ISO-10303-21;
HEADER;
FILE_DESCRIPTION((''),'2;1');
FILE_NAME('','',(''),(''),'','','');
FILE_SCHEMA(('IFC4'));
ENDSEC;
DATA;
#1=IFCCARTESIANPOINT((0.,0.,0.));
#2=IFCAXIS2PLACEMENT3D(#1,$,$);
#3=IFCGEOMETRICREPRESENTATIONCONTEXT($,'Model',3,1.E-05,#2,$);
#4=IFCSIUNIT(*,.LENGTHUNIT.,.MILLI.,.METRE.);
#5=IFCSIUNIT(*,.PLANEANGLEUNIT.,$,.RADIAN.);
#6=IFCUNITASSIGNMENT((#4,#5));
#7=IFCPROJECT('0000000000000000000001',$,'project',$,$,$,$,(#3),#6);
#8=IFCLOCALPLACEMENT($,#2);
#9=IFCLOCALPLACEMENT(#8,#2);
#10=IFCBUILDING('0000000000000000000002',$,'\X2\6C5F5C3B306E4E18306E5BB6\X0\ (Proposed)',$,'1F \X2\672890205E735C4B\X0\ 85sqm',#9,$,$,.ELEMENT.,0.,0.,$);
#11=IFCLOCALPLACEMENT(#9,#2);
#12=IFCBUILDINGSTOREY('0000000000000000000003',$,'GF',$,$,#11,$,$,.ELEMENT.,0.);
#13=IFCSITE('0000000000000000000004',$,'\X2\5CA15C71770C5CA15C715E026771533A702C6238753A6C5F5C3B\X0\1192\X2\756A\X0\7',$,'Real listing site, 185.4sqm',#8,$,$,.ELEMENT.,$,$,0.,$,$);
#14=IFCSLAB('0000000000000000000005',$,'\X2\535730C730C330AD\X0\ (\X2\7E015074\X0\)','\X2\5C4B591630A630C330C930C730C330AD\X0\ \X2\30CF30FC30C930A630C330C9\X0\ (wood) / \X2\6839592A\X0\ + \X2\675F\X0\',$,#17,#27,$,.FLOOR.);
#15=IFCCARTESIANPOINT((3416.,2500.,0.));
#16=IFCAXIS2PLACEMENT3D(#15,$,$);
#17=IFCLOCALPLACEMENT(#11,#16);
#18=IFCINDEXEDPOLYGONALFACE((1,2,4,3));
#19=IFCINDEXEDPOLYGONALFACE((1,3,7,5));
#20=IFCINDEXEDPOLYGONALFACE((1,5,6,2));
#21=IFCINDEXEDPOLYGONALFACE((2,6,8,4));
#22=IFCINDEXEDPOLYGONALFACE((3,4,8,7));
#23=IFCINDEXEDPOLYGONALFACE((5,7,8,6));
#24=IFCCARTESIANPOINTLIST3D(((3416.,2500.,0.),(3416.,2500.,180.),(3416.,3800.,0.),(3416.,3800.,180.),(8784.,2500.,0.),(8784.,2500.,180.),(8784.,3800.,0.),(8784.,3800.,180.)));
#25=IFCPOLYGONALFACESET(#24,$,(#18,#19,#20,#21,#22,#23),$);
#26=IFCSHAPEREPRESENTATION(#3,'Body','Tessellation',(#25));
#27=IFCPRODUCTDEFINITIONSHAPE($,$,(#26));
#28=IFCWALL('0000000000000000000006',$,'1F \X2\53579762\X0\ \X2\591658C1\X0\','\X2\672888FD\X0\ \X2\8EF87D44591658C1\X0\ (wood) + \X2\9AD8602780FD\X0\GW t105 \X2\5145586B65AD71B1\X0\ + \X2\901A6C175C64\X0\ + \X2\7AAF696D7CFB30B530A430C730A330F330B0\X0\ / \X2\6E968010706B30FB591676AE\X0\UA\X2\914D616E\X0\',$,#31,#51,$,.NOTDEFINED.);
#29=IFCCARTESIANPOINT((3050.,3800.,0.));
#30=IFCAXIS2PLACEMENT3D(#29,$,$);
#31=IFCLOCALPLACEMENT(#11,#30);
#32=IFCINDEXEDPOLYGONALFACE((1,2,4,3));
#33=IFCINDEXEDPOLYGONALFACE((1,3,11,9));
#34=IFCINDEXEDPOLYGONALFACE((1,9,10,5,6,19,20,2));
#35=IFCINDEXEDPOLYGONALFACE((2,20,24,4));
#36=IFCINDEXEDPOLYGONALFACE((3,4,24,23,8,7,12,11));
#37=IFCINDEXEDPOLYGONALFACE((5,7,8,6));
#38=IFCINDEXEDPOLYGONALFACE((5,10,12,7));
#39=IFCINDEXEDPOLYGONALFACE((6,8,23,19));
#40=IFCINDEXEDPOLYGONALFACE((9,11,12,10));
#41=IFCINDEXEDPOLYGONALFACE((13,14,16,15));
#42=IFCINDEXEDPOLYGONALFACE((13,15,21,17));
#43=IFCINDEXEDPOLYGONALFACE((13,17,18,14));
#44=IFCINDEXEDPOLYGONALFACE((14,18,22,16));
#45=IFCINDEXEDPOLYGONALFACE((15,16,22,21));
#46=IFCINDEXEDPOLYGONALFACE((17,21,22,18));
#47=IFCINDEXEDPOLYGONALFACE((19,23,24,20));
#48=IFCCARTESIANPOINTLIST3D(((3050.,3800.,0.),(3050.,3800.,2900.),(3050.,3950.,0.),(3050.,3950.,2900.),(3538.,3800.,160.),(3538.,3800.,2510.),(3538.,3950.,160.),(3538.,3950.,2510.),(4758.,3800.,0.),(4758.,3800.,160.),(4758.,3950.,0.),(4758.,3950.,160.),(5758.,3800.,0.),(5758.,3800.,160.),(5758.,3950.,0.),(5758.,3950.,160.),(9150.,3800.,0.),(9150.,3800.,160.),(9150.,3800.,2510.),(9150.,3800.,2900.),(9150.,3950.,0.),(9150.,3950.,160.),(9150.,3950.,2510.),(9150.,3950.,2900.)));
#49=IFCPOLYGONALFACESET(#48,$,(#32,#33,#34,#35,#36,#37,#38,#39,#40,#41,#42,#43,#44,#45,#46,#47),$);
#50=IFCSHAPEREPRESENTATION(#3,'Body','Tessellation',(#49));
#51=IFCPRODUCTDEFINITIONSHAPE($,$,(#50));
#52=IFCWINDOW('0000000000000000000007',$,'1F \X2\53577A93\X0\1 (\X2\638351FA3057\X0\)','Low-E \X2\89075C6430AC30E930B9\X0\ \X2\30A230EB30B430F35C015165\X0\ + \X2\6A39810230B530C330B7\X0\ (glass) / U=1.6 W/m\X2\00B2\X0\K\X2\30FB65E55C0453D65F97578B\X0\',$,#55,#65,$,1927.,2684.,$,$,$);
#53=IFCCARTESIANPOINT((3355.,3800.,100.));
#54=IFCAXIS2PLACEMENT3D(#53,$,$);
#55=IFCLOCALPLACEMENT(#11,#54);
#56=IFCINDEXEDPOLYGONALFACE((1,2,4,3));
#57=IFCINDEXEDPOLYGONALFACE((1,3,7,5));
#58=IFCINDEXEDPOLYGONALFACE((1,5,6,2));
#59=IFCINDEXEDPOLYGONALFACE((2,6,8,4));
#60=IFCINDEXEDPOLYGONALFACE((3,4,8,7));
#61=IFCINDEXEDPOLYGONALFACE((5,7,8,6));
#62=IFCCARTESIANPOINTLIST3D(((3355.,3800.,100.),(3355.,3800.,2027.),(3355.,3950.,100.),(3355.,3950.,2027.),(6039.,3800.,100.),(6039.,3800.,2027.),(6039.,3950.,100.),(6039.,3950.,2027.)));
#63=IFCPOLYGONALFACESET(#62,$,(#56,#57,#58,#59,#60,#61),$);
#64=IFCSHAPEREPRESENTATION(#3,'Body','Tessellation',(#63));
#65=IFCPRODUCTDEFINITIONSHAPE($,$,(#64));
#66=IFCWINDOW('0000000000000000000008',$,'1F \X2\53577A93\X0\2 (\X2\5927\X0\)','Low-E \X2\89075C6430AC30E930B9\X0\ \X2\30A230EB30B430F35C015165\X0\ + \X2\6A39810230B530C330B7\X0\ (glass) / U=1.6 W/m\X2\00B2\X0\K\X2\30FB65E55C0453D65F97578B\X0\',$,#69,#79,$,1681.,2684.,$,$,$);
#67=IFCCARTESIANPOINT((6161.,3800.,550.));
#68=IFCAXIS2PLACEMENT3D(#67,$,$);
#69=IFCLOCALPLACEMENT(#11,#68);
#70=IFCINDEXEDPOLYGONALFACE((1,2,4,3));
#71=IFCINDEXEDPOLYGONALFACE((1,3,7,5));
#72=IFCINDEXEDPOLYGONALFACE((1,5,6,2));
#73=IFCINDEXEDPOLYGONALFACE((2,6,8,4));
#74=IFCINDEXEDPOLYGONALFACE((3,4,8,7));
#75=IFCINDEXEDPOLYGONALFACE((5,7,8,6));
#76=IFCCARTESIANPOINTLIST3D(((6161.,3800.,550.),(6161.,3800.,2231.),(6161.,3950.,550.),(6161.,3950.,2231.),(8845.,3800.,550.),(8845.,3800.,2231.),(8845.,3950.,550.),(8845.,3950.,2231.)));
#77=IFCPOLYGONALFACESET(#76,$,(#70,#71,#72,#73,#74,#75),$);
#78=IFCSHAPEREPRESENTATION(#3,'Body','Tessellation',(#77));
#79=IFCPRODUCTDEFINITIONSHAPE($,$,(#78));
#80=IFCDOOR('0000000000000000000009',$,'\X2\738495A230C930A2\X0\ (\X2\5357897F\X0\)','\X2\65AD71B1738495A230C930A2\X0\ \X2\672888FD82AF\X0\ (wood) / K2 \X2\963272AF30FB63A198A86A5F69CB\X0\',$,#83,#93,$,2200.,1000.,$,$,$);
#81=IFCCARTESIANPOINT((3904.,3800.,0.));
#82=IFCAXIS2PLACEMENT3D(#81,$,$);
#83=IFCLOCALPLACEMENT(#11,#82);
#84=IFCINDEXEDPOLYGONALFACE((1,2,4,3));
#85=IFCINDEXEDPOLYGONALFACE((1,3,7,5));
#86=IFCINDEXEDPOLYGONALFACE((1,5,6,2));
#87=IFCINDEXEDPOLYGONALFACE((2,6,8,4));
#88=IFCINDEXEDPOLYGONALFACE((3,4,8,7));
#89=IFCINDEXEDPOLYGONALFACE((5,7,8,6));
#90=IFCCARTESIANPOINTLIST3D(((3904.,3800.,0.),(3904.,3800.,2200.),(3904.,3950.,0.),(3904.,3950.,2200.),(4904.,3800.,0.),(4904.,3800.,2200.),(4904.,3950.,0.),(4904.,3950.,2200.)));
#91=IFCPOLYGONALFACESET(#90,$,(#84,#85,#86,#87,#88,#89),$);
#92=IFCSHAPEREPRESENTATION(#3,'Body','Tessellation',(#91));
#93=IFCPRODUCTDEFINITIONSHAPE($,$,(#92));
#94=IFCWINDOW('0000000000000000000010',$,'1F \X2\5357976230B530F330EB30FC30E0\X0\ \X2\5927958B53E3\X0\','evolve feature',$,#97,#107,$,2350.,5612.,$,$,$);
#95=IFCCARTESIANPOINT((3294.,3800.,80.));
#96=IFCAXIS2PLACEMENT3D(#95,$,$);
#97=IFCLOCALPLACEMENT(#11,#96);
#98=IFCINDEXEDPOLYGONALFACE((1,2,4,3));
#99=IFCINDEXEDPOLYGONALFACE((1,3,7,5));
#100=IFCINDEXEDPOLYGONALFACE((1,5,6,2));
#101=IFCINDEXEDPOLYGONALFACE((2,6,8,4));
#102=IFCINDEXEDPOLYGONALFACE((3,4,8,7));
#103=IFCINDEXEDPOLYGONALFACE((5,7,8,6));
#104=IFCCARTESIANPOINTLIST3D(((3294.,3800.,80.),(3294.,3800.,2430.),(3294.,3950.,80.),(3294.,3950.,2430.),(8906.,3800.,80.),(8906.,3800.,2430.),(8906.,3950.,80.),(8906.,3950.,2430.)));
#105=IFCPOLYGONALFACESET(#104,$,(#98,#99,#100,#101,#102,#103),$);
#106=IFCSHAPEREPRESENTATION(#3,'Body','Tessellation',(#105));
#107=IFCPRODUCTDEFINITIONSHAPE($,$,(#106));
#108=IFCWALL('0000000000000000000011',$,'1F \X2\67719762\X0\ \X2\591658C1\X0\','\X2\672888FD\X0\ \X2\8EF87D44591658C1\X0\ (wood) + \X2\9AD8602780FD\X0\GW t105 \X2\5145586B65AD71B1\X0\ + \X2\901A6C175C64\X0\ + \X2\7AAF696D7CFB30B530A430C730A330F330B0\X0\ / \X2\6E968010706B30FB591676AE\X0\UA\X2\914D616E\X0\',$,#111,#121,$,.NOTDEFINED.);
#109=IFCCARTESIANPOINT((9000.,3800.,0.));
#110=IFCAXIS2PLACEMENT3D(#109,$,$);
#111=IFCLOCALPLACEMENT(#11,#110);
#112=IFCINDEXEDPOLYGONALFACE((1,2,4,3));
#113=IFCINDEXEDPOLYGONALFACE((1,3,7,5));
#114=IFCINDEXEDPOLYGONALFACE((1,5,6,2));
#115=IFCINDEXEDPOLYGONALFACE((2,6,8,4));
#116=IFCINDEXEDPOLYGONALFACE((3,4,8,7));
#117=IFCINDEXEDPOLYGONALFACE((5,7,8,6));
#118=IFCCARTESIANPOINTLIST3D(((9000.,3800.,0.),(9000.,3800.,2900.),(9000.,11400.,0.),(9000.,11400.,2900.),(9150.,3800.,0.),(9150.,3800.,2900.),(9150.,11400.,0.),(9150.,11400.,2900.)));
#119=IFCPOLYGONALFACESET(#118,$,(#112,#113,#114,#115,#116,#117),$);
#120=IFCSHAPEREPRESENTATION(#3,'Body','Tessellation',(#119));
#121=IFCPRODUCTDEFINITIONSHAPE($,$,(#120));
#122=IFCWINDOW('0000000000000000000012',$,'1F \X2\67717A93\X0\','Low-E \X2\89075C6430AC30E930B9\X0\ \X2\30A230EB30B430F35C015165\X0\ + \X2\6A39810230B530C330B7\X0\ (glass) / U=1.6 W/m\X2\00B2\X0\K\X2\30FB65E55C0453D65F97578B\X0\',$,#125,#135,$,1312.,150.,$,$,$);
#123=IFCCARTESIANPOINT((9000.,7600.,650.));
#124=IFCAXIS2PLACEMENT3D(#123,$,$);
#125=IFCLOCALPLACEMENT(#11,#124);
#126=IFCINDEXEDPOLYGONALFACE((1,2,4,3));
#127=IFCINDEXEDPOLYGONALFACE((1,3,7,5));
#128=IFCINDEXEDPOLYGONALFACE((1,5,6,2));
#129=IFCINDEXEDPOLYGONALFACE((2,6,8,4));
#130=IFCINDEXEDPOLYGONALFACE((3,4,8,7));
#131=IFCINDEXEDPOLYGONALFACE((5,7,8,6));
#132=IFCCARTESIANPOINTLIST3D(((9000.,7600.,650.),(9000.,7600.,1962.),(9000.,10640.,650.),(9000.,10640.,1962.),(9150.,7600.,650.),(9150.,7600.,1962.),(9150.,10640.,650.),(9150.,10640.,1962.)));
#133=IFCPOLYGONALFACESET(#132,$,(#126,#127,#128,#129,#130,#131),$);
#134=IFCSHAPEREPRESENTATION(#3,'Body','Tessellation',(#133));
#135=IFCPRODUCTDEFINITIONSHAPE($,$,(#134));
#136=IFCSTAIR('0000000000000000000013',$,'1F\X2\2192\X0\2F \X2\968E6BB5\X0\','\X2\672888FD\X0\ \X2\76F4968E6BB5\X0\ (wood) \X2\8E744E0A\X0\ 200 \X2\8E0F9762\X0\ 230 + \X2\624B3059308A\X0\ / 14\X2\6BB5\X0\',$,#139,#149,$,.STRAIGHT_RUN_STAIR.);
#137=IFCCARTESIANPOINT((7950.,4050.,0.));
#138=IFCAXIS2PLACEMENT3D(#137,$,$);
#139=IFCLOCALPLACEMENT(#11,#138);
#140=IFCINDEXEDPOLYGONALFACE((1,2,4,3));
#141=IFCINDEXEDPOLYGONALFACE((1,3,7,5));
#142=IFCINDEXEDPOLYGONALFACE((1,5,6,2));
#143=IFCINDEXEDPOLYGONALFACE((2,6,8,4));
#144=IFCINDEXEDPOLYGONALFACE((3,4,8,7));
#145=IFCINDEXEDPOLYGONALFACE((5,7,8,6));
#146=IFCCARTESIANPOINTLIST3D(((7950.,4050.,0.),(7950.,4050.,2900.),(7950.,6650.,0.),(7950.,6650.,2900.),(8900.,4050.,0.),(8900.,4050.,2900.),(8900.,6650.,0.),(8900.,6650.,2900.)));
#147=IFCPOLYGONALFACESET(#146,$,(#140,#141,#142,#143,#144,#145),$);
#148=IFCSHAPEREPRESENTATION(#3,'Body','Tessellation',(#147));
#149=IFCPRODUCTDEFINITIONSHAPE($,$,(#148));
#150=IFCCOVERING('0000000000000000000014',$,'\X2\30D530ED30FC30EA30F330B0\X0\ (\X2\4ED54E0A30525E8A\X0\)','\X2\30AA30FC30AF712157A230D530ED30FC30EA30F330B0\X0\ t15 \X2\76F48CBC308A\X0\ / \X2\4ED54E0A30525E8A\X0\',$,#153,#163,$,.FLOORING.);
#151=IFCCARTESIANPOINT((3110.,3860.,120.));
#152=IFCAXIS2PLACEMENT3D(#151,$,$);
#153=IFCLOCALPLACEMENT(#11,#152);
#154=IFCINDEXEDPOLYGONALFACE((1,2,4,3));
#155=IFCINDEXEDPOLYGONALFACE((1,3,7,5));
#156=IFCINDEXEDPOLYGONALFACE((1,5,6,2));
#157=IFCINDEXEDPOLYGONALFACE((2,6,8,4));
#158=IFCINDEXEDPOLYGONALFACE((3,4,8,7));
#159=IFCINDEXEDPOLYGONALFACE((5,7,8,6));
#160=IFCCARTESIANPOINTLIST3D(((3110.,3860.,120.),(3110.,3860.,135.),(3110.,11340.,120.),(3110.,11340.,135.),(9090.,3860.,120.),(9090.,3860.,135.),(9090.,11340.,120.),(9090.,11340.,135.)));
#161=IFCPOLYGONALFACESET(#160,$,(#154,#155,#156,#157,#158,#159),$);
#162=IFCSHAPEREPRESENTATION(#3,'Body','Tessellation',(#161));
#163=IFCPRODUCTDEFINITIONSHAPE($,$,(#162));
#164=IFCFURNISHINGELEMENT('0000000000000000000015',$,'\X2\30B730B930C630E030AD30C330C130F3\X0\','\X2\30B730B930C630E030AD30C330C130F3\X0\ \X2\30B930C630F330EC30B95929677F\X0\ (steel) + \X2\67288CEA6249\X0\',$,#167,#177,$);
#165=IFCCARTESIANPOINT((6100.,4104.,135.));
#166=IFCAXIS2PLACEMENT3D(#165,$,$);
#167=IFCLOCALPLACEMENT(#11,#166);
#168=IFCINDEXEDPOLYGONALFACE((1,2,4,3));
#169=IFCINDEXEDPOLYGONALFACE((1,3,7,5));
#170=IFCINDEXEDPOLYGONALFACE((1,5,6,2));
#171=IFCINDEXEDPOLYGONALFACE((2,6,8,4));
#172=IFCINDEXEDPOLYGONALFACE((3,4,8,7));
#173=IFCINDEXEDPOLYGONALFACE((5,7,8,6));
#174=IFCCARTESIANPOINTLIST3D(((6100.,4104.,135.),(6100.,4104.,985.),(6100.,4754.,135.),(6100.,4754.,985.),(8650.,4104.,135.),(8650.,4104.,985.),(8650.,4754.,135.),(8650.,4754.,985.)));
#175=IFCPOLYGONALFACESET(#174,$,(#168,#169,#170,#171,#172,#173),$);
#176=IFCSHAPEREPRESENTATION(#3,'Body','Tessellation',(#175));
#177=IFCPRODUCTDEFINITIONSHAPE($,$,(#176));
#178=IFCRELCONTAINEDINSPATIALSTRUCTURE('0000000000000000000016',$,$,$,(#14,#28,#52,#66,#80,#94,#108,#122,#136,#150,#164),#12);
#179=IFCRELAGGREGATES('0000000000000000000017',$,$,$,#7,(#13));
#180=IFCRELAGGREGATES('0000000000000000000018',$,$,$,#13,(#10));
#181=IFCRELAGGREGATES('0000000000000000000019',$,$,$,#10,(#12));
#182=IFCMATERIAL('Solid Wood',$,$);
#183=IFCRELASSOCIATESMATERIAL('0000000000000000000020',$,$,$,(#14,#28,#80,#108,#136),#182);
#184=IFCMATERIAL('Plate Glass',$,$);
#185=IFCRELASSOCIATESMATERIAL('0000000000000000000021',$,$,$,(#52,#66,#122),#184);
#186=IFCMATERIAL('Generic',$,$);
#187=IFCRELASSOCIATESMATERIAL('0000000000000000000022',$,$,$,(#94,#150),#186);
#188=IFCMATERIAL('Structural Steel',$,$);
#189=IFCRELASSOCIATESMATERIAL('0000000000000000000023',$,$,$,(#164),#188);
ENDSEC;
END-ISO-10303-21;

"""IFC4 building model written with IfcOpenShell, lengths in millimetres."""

from ifc_helpers import new_model, si_unit, frame, frame_2d, origin, place, context, project, spatial, rectangle, extrude, material, element, fill, save


model = new_model("IFC4")

# Units and contexts
model_context = context("Model", 3, precision=1e-05, world=origin())
ifc_project = project(units=[si_unit("LENGTHUNIT", "METRE", prefix="MILLI"), si_unit("PLANEANGLEUNIT", "RADIAN")], contexts=[model_context])

# Site, building, storey
site_placement = place(None, origin())
site = spatial("IfcSite", under=ifc_project, at=site_placement, Name="岡山県岡山市東区瀬戸町江尻1192番7", ObjectType="Real listing site, 185.4sqm", CompositionType="ELEMENT", RefElevation=0.0)
building_placement = place(site_placement, origin())
building = spatial("IfcBuilding", under=site, at=building_placement, Name="江尻の丘の家 (Proposed)", ObjectType="1F 木造平屋 85sqm", CompositionType="ELEMENT", ElevationOfRefHeight=0.0, ElevationOfTerrain=0.0)
storey_placement = place(building_placement, origin())
storey = spatial("IfcBuildingStorey", under=building, at=storey_placement, Name="GF", CompositionType="ELEMENT", Elevation=0.0)

# Slab
ifc_material_1 = material(Name="Solid Wood")
slab_1_placement = place(storey_placement, frame((3416.0, 2500.0, 0.0)))
element("IfcSlab", 1, at=slab_1_placement, inside=storey, material=ifc_material_1, Name="南デッキ (縁側)", Description="屋外ウッドデッキ ハードウッド (wood) / 根太 + 束", PredefinedType="FLOOR", context=model_context, shape_type="SweptSolid", body=[
    extrude(rectangle(XDim=5368.0, YDim=1300.0, at=frame_2d((2684.0, 650.0))), frame((3416.0, 2500.0, 0.0)), (0.0, 0.0, 1.0), 180.0),
])
ifc_material_2 = material(Name="Generic")

# Wall, openings, windows, door
wall_1_placement = place(storey_placement, frame((3050.0, 3800.0, 0.0)))
wall_1 = element("IfcWall", 2, at=wall_1_placement, inside=storey, material=ifc_material_1, Name="1F 南面 外壁", Description="木製 軸組外壁 (wood) + 高性能GW t105 充填断熱 + 通気層 + 窯業系サイディング / 準耐火・外皮UA配慮", PredefinedType="NOTDEFINED", context=model_context, shape_type="SweptSolid", body=[
    extrude(rectangle(XDim=6100.0, YDim=150.0, at=frame_2d((3050.0, 75.0))), frame((3050.0, 3800.0, 0.0)), (0.0, 0.0, 1.0), 2900.0),
])
opening_1_placement = place(storey_placement, frame((3355.0, 3800.0, 100.0)))
opening_1 = element("IfcOpeningElement", 3, at=opening_1_placement, cuts=wall_1, PredefinedType="NOTDEFINED", context=model_context, shape_type="SweptSolid", body=[
    extrude(rectangle(XDim=2684.0, YDim=150.0, at=frame_2d((1342.0, 75.0))), frame((3355.0, 3800.0, 100.0)), (0.0, 0.0, 1.0), 1927.0),
])
opening_2_placement = place(storey_placement, frame((6161.0, 3800.0, 550.0)))
opening_2 = element("IfcOpeningElement", 4, at=opening_2_placement, cuts=wall_1, PredefinedType="NOTDEFINED", context=model_context, shape_type="SweptSolid", body=[
    extrude(rectangle(XDim=2684.0, YDim=150.0, at=frame_2d((1342.0, 75.0))), frame((6161.0, 3800.0, 550.0)), (0.0, 0.0, 1.0), 1681.0),
])
opening_3_placement = place(storey_placement, frame((3904.0, 3800.0, 0.0)))
opening_3 = element("IfcOpeningElement", 5, at=opening_3_placement, cuts=wall_1, PredefinedType="NOTDEFINED", context=model_context, shape_type="SweptSolid", body=[
    extrude(rectangle(XDim=1000.0, YDim=150.0, at=frame_2d((500.0, 75.0))), frame((3904.0, 3800.0, 0.0)), (0.0, 0.0, 1.0), 2200.0),
])
opening_4_placement = place(storey_placement, frame((3294.0, 3800.0, 80.0)))
opening_4 = element("IfcOpeningElement", 6, at=opening_4_placement, cuts=wall_1, PredefinedType="NOTDEFINED", context=model_context, shape_type="SweptSolid", body=[
    extrude(rectangle(XDim=5612.0, YDim=150.0, at=frame_2d((2806.0, 75.0))), frame((3294.0, 3800.0, 80.0)), (0.0, 0.0, 1.0), 2350.0),
])
ifc_material_3 = material(Name="Plate Glass")
window_1_placement = place(storey_placement, frame((3355.0, 3800.0, 100.0)))
window_1 = element("IfcWindow", 7, at=window_1_placement, inside=storey, material=ifc_material_3, Name="1F 南窓1 (掃出し)", Description="Low-E 複層ガラス アルゴン封入 + 樹脂サッシ (glass) / U=1.6 W/m²K・日射取得型", OverallHeight=1927.0, OverallWidth=2684.0, context=model_context, shape_type="SweptSolid", body=[
    extrude(rectangle(XDim=2684.0, YDim=150.0, at=frame_2d((1342.0, 75.0))), frame((3355.0, 3800.0, 100.0)), (0.0, 0.0, 1.0), 1927.0),
])
fill(opening_1, window_1)
window_2_placement = place(storey_placement, frame((6161.0, 3800.0, 550.0)))
window_2 = element("IfcWindow", 8, at=window_2_placement, inside=storey, material=ifc_material_3, Name="1F 南窓2 (大)", Description="Low-E 複層ガラス アルゴン封入 + 樹脂サッシ (glass) / U=1.6 W/m²K・日射取得型", OverallHeight=1681.0, OverallWidth=2684.0, context=model_context, shape_type="SweptSolid", body=[
    extrude(rectangle(XDim=2684.0, YDim=150.0, at=frame_2d((1342.0, 75.0))), frame((6161.0, 3800.0, 550.0)), (0.0, 0.0, 1.0), 1681.0),
])
fill(opening_2, window_2)
door_placement = place(storey_placement, frame((3904.0, 3800.0, 0.0)))
door = element("IfcDoor", 9, at=door_placement, inside=storey, material=ifc_material_1, Name="玄関ドア (南西)", Description="断熱玄関ドア 木製芯 (wood) / K2 防犯・採風機構", OverallHeight=2200.0, OverallWidth=1000.0, context=model_context, shape_type="SweptSolid", body=[
    extrude(rectangle(XDim=1000.0, YDim=150.0, at=frame_2d((500.0, 75.0))), frame((3904.0, 3800.0, 0.0)), (0.0, 0.0, 1.0), 2200.0),
])
fill(opening_3, door)
window_3_placement = place(storey_placement, frame((3294.0, 3800.0, 80.0)))
window_3 = element("IfcWindow", 10, at=window_3_placement, inside=storey, material=ifc_material_2, Name="1F 南面サンルーム 大開口", Description="evolve feature", OverallHeight=2350.0, OverallWidth=5612.0, context=model_context, shape_type="SweptSolid", body=[
    extrude(rectangle(XDim=5612.0, YDim=150.0, at=frame_2d((2806.0, 75.0))), frame((3294.0, 3800.0, 80.0)), (0.0, 0.0, 1.0), 2350.0),
])
fill(opening_4, window_3)

# Wall, opening, window
wall_2_placement = place(storey_placement, frame((9000.0, 3800.0, 0.0)))
wall_2 = element("IfcWall", 11, at=wall_2_placement, inside=storey, material=ifc_material_1, Name="1F 東面 外壁", Description="木製 軸組外壁 (wood) + 高性能GW t105 充填断熱 + 通気層 + 窯業系サイディング / 準耐火・外皮UA配慮", PredefinedType="NOTDEFINED", context=model_context, shape_type="SweptSolid", body=[
    extrude(rectangle(XDim=150.0, YDim=7600.0, at=frame_2d((75.0, 3800.0))), frame((9000.0, 3800.0, 0.0)), (0.0, 0.0, 1.0), 2900.0),
])
opening_5_placement = place(storey_placement, frame((9000.0, 7600.0, 650.0)))
opening_5 = element("IfcOpeningElement", 12, at=opening_5_placement, cuts=wall_2, PredefinedType="NOTDEFINED", context=model_context, shape_type="SweptSolid", body=[
    extrude(rectangle(XDim=150.0, YDim=3040.0, at=frame_2d((75.0, 1520.0))), frame((9000.0, 7600.0, 650.0)), (0.0, 0.0, 1.0), 1312.0),
])
window_4_placement = place(storey_placement, frame((9000.0, 7600.0, 650.0)))
window_4 = element("IfcWindow", 13, at=window_4_placement, inside=storey, material=ifc_material_3, Name="1F 東窓", Description="Low-E 複層ガラス アルゴン封入 + 樹脂サッシ (glass) / U=1.6 W/m²K・日射取得型", OverallHeight=1312.0, OverallWidth=150.0, context=model_context, shape_type="SweptSolid", body=[
    extrude(rectangle(XDim=150.0, YDim=3040.0, at=frame_2d((75.0, 1520.0))), frame((9000.0, 7600.0, 650.0)), (0.0, 0.0, 1.0), 1312.0),
])
fill(opening_5, window_4)

# Stair
stair_placement = place(storey_placement, frame((7950.0, 4050.0, 0.0)))
element("IfcStair", 14, at=stair_placement, inside=storey, material=ifc_material_1, Name="1F→2F 階段", Description="木製 直階段 (wood) 蹴上 200 踏面 230 + 手すり / 14段", PredefinedType="STRAIGHT_RUN_STAIR", context=model_context, shape_type="SweptSolid", body=[
    extrude(rectangle(XDim=950.0, YDim=2600.0, at=frame_2d((475.0, 1300.0))), frame((7950.0, 4050.0, 0.0)), (0.0, 0.0, 1.0), 2900.0),
])

# Covering
covering_placement = place(storey_placement, frame((3110.0, 3860.0, 120.0)))
element("IfcCovering", 15, at=covering_placement, inside=storey, material=ifc_material_2, Name="フローリング (仕上げ床)", Description="オーク無垢フローリング t15 直貼り / 仕上げ床", PredefinedType="FLOORING", context=model_context, shape_type="SweptSolid", body=[
    extrude(rectangle(XDim=5980.0, YDim=7480.0, at=frame_2d((2990.0, 3740.0))), frame((3110.0, 3860.0, 120.0)), (0.0, 0.0, 1.0), 15.0),
])

# Furnishing element
ifc_material_4 = material(Name="Structural Steel")
furnishing_placement = place(storey_placement, frame((6100.0, 4104.0, 135.0)))
element("IfcFurnishingElement", 16, at=furnishing_placement, inside=storey, material=ifc_material_4, Name="システムキッチン", Description="システムキッチン ステンレス天板 (steel) + 木質扉", context=model_context, shape_type="SweptSolid", body=[
    extrude(rectangle(XDim=2550.0, YDim=650.0, at=frame_2d((1275.0, 325.0))), frame((6100.0, 4104.0, 135.0)), (0.0, 0.0, 1.0), 850.0),
])

save(model, "model.ifc")
